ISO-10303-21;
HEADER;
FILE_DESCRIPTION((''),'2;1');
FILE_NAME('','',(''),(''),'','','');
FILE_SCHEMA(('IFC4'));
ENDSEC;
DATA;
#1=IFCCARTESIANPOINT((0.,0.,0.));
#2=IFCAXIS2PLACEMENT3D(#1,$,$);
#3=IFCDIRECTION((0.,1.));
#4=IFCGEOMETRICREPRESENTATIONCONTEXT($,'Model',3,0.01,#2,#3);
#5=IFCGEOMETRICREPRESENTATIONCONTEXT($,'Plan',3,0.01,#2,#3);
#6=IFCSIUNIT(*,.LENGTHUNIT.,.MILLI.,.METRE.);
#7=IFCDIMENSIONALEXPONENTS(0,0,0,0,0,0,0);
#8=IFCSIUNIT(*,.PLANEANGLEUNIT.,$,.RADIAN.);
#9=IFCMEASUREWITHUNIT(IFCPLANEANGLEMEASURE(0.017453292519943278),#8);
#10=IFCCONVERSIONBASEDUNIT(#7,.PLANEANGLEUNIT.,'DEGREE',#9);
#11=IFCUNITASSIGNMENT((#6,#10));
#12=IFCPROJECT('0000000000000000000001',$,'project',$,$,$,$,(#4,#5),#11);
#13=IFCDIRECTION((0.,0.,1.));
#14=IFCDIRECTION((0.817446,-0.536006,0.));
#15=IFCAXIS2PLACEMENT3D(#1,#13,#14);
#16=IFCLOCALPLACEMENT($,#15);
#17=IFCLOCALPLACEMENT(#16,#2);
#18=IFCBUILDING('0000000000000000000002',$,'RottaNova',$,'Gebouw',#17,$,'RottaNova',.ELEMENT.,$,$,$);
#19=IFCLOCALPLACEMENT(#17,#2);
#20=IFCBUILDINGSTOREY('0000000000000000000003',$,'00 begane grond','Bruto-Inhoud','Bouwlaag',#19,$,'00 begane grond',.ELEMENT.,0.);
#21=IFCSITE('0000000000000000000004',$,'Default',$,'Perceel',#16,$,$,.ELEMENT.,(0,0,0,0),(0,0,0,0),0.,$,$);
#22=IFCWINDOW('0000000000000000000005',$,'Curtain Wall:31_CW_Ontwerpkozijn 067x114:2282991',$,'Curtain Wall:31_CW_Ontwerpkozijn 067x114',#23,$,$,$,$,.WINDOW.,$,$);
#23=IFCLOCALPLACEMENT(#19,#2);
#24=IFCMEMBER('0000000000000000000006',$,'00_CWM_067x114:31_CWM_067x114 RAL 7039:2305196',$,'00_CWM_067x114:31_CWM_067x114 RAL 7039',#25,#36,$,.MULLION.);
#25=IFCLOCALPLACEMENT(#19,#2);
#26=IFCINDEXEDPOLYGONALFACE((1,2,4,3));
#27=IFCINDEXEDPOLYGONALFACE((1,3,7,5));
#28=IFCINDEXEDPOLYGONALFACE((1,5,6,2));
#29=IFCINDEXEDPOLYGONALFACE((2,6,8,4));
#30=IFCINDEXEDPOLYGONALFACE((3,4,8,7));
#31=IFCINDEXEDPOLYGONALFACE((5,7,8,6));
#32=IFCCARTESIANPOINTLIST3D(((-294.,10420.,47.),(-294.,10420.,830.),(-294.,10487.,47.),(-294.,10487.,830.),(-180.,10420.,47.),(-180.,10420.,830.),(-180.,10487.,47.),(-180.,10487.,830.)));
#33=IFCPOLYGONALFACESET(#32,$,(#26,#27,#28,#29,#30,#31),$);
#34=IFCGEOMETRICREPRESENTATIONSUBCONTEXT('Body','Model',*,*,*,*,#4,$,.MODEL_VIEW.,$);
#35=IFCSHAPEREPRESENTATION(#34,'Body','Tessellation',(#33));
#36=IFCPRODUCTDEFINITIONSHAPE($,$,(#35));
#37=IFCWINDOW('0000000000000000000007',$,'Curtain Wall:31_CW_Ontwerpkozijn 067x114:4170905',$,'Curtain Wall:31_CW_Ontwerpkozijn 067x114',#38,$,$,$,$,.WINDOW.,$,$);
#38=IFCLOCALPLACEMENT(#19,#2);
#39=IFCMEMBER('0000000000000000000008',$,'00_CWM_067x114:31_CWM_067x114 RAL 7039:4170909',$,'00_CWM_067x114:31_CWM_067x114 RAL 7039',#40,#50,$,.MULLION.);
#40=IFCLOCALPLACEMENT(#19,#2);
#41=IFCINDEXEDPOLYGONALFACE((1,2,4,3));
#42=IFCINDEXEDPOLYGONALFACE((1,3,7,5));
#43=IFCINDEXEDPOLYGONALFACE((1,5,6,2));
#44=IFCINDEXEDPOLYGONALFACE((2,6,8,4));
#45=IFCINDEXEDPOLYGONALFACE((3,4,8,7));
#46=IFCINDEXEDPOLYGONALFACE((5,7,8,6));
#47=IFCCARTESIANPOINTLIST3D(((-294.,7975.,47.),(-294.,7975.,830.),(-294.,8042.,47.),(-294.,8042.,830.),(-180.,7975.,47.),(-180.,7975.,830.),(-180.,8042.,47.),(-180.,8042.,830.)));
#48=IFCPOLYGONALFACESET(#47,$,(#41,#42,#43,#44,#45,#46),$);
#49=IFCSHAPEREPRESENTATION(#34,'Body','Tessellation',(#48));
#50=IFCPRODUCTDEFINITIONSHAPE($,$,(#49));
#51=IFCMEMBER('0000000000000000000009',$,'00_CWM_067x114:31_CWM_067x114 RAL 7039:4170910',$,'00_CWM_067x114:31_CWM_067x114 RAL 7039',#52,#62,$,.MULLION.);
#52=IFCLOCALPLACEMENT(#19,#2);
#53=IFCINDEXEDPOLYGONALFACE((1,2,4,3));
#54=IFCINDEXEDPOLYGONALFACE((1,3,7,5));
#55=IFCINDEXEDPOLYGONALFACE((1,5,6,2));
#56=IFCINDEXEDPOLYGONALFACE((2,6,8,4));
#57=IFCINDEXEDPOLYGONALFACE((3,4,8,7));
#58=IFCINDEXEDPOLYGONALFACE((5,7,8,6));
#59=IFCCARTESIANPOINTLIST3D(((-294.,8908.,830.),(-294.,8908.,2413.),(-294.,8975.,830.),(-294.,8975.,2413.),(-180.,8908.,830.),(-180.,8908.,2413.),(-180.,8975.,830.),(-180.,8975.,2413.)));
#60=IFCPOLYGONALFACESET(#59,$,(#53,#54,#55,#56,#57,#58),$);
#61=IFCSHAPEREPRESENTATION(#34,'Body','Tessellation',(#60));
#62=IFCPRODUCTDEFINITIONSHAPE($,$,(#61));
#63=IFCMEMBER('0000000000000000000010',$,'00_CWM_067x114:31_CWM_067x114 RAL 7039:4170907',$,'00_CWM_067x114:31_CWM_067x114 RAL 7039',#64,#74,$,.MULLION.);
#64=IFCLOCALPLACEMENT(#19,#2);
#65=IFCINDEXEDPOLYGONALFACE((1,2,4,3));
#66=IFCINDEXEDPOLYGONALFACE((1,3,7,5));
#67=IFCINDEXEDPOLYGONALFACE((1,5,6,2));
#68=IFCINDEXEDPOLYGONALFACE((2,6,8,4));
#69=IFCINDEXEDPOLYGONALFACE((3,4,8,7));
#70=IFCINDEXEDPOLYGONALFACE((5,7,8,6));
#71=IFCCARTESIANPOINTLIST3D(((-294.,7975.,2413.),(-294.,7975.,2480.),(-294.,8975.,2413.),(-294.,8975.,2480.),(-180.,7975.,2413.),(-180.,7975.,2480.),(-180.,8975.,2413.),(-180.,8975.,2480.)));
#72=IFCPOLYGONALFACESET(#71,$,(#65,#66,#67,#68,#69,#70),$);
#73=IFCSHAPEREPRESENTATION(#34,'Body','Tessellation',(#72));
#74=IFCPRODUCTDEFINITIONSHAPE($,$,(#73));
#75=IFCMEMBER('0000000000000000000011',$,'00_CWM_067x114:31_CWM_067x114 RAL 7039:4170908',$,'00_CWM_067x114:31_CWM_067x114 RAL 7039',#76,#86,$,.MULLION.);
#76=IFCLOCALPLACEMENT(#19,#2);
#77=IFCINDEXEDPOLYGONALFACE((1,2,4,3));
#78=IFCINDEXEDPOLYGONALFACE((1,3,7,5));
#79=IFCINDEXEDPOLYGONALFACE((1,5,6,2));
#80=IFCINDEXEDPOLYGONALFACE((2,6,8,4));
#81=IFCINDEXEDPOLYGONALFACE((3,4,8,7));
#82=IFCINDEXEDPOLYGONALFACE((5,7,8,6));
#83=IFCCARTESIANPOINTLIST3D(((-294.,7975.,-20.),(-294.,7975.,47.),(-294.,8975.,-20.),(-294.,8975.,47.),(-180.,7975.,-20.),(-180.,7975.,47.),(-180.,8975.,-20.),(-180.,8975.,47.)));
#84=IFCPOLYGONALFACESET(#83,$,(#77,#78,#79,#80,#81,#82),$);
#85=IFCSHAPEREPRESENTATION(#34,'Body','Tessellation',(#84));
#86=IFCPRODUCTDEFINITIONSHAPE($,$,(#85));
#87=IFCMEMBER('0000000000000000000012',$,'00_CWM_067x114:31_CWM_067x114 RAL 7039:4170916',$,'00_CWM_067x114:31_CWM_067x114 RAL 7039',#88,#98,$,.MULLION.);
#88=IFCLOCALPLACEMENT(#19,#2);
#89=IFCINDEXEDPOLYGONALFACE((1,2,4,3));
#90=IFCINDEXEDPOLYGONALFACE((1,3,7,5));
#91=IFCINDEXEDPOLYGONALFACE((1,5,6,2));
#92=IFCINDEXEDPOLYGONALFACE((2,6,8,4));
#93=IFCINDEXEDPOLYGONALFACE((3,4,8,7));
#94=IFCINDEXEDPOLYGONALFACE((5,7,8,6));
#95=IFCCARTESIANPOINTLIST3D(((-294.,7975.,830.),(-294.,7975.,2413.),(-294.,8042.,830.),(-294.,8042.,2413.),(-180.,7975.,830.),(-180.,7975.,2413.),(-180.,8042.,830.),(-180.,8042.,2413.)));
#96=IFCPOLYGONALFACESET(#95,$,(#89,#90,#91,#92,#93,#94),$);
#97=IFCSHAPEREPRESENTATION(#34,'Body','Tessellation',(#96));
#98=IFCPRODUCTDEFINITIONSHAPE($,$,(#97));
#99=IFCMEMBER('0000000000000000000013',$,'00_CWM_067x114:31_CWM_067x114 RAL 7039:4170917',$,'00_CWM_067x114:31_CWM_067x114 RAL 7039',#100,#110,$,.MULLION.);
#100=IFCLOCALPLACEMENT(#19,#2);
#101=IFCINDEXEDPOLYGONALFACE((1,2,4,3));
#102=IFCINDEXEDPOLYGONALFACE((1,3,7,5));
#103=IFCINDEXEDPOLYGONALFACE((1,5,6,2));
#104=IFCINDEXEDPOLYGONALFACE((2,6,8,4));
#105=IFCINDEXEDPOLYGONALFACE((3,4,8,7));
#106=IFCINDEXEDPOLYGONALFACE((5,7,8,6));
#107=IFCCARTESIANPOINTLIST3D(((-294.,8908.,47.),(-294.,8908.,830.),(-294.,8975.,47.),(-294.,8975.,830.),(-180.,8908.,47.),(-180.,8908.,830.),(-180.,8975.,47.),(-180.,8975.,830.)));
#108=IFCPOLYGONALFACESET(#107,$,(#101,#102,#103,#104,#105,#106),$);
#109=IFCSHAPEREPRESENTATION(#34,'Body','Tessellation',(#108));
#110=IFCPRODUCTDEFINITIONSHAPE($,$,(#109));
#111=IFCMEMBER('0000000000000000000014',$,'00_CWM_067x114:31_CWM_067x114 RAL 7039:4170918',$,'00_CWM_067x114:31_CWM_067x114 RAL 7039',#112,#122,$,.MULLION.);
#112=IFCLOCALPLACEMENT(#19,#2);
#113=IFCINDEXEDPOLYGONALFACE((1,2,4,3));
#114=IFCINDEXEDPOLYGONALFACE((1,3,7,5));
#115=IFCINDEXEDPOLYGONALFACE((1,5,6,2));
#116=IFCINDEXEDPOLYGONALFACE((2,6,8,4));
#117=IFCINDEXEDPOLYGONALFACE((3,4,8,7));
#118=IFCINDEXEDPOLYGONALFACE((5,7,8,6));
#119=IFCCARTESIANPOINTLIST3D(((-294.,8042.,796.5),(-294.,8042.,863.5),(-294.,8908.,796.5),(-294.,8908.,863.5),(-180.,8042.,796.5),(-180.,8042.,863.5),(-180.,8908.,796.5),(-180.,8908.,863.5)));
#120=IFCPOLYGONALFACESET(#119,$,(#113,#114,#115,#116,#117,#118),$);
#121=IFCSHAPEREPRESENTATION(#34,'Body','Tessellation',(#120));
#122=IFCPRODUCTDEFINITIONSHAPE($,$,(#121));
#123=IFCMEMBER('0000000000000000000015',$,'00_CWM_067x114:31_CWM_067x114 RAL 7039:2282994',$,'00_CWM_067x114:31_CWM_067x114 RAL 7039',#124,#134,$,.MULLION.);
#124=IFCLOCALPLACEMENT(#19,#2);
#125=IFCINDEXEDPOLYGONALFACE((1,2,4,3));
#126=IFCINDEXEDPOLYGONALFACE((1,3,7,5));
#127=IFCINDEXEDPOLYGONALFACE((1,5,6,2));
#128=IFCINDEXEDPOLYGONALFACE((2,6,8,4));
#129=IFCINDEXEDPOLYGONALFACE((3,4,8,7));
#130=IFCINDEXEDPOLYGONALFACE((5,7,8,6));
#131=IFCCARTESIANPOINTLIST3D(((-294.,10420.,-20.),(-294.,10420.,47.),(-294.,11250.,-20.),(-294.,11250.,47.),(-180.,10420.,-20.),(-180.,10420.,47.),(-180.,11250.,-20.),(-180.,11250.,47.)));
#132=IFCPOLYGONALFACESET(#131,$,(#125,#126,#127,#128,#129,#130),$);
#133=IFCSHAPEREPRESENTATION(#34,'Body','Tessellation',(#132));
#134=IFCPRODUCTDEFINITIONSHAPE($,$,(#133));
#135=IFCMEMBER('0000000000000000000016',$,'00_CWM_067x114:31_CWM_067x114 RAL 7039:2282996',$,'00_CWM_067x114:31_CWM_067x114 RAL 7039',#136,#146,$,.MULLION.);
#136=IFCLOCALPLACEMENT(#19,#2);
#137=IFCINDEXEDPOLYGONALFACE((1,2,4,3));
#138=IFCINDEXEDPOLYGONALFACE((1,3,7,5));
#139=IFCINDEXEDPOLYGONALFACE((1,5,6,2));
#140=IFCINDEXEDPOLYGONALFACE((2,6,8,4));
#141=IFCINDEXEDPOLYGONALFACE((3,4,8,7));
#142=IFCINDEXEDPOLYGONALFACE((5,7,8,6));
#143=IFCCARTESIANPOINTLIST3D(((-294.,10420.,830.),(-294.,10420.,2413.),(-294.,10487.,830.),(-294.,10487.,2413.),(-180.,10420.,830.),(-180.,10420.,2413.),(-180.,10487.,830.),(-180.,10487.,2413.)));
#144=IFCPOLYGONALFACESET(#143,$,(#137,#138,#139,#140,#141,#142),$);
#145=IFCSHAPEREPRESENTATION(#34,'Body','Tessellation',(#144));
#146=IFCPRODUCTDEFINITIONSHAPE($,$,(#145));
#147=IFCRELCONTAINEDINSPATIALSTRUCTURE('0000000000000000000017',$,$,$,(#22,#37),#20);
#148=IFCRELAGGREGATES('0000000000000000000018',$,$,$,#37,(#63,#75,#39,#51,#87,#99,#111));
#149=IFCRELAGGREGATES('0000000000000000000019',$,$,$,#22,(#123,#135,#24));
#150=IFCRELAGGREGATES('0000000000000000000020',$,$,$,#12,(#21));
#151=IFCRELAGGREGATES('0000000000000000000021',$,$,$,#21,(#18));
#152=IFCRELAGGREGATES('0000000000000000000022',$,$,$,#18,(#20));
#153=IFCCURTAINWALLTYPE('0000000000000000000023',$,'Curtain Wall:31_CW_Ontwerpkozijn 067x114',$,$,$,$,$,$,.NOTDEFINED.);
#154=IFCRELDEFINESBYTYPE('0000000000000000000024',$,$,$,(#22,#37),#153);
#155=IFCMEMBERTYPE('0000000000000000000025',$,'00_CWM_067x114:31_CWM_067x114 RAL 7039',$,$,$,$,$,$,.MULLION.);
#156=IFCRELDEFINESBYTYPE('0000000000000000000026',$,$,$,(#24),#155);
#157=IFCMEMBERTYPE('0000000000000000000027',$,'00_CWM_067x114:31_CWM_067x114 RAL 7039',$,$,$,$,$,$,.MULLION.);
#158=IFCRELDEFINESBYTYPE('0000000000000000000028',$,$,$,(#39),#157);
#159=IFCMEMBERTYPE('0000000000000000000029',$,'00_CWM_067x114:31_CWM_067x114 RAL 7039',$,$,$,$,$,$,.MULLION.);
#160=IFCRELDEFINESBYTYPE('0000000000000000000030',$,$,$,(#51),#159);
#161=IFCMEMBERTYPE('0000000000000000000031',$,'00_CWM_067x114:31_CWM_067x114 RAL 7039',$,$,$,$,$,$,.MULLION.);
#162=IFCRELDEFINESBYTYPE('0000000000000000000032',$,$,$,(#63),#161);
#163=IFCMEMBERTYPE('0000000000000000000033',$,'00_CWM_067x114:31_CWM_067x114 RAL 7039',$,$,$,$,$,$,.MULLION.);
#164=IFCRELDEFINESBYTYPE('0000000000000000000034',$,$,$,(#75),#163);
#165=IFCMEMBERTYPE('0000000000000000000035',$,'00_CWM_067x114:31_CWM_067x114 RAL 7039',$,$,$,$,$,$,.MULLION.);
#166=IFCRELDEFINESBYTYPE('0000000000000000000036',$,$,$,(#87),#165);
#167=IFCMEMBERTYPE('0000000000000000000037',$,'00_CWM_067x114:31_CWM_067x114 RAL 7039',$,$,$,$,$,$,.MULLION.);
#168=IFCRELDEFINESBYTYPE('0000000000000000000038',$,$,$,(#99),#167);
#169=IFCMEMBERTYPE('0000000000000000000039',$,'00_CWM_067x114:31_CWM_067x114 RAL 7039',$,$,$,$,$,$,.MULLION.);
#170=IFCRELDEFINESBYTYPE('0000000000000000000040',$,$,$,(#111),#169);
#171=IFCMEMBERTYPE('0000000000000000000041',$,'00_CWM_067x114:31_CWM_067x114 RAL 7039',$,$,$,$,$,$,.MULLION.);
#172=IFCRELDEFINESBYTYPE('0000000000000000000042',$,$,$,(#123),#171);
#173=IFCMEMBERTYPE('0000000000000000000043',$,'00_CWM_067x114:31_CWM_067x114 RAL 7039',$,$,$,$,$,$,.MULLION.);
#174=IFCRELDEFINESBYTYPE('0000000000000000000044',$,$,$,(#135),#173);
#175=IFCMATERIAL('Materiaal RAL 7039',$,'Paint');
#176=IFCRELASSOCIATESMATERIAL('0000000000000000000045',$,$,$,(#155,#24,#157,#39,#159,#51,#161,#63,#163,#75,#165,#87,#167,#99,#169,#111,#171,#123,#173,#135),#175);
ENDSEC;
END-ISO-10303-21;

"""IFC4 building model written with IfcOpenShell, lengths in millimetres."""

from ifc_helpers import new_model, entity, si_unit, converted_unit, direction, frame, origin, place, context, subcontext, project, spatial, indexed_curve, outline, extrude, source, transform, mapped, material, type_object, type_shapes, element, aggregate, save


model = new_model("IFC4")

# Units and contexts
model_context = context("Model", 3, precision=0.01, world=origin(), true_north=direction((0.0, 1.0)))
plan_context = context("Plan", 3, precision=0.01, world=origin(), true_north=direction((0.0, 1.0)))
body_context = subcontext(model_context, "Body", "Model", "MODEL_VIEW")
ifc_project = project(units=[si_unit("LENGTHUNIT", "METRE", prefix="MILLI"), converted_unit("PLANEANGLEUNIT", "DEGREE", entity("IfcPlaneAngleMeasure", 0.017453292519943278), si_unit("PLANEANGLEUNIT", "RADIAN"), dimensions=[0, 0, 0, 0, 0, 0, 0])], contexts=[model_context, plan_context])

# Site, building, storey
site_placement = place(None, frame((0.0, 0.0, 0.0), z_axis=(0.0, 0.0, 1.0), x_axis=(0.817446, -0.536006, 0.0)))
site = spatial("IfcSite", under=ifc_project, at=site_placement, Name="Default", ObjectType="Perceel", CompositionType="ELEMENT", RefLatitude=(0, 0, 0, 0), RefLongitude=(0, 0, 0, 0), RefElevation=0.0)
building_placement = place(site_placement, origin())
building = spatial("IfcBuilding", under=site, at=building_placement, Name="RottaNova", ObjectType="Gebouw", LongName="RottaNova", CompositionType="ELEMENT")
storey_placement = place(building_placement, origin())
storey = spatial("IfcBuildingStorey", under=building, at=storey_placement, Name="00 begane grond", Description="Bruto-Inhoud", ObjectType="Bouwlaag", LongName="00 begane grond", CompositionType="ELEMENT", Elevation=0.0)

# Window, member
curtain_wall_type = type_object("IfcCurtainWallType", Name="Curtain Wall:31_CW_Ontwerpkozijn 067x114", PredefinedType="NOTDEFINED")
window_1_placement = place(storey_placement, origin())
window_1 = element("IfcWindow", 1, at=window_1_placement, inside=storey, type_object=curtain_wall_type, Name="Curtain Wall:31_CW_Ontwerpkozijn 067x114:2282991", ObjectType="Curtain Wall:31_CW_Ontwerpkozijn 067x114", PredefinedType="WINDOW")
ifc_material_1 = material(Name="Materiaal RAL 7039", Category="Paint")
member_type_1 = type_object("IfcMemberType", Name="00_CWM_067x114:31_CWM_067x114 RAL 7039", PredefinedType="MULLION", material=ifc_material_1)
shared_shape_1 = source(origin(), body_context, "Body", "SweptSolid", [
    extrude(outline(indexed_curve([(-33.5, -57.0), (33.5, -57.0), (33.5, 57.0), (-33.5, 57.0), (-33.5, -57.0)], self_intersect=False)), frame((-33.5, -57.0, -783.0), z_axis=(0.0, 0.0, 1.0), x_axis=(-1.0, 0.0, 0.0)), (0.0, 0.0, 1.0), 783.0),
])
type_shapes(member_type_1, [shared_shape_1])
member_1_placement = place(window_1_placement, frame((-180.0, 10420.0, 830.0), z_axis=(0.0, 0.0, 1.0), x_axis=(0.0, -1.0, 0.0)))
member_1 = element("IfcMember", 2, at=member_1_placement, type_object=member_type_1, material=ifc_material_1, Name="00_CWM_067x114:31_CWM_067x114 RAL 7039:2305196", ObjectType="00_CWM_067x114:31_CWM_067x114 RAL 7039", PredefinedType="MULLION", context=body_context, shape_type="MappedRepresentation", body=[
    mapped(shared_shape_1, transform((0.0, 0.0, 0.0), scale=1.0)),
])

# Window, members
window_2_placement = place(storey_placement, origin())
window_2 = element("IfcWindow", 3, at=window_2_placement, inside=storey, type_object=curtain_wall_type, Name="Curtain Wall:31_CW_Ontwerpkozijn 067x114:4170905", ObjectType="Curtain Wall:31_CW_Ontwerpkozijn 067x114", PredefinedType="WINDOW")
member_type_2 = type_object("IfcMemberType", Name="00_CWM_067x114:31_CWM_067x114 RAL 7039", PredefinedType="MULLION", material=ifc_material_1)
shared_shape_2 = source(origin(), body_context, "Body", "SweptSolid", [
    extrude(outline(indexed_curve([(-33.5, -57.0), (33.5, -57.0), (33.5, 57.0), (-33.5, 57.0), (-33.5, -57.0)], self_intersect=False)), frame((-33.5, 57.0, -783.0), z_axis=(0.0, 0.0, 1.0), x_axis=(-1.0, 0.0, 0.0)), (0.0, 0.0, 1.0), 783.0),
])
type_shapes(member_type_2, [shared_shape_2])
member_2_placement = place(window_2_placement, frame((-180.0, 7975.0, 47.0), z_axis=(0.0, 0.0, -1.0), x_axis=(0.0, -1.0, 0.0)))
member_2 = element("IfcMember", 4, at=member_2_placement, type_object=member_type_2, material=ifc_material_1, Name="00_CWM_067x114:31_CWM_067x114 RAL 7039:4170909", ObjectType="00_CWM_067x114:31_CWM_067x114 RAL 7039", PredefinedType="MULLION", context=body_context, shape_type="MappedRepresentation", body=[
    mapped(shared_shape_2, transform((0.0, 0.0, 0.0), scale=1.0)),
])
member_type_3 = type_object("IfcMemberType", Name="00_CWM_067x114:31_CWM_067x114 RAL 7039", PredefinedType="MULLION", material=ifc_material_1)
shared_shape_3 = source(origin(), body_context, "Body", "SweptSolid", [
    extrude(outline(indexed_curve([(-33.5, -57.0), (33.5, -57.0), (33.5, 57.0), (-33.5, 57.0), (-33.5, -57.0)], self_intersect=False)), frame((-33.5, 57.0, -1583.0), z_axis=(0.0, 0.0, 1.0), x_axis=(-1.0, 0.0, 0.0)), (0.0, 0.0, 1.0), 1583.0),
])
type_shapes(member_type_3, [shared_shape_3])
member_3_placement = place(window_2_placement, frame((-180.0, 8975.0, 2413.0), z_axis=(0.0, 0.0, 1.0), x_axis=(0.0, 1.0, 0.0)))
member_3 = element("IfcMember", 5, at=member_3_placement, type_object=member_type_3, material=ifc_material_1, Name="00_CWM_067x114:31_CWM_067x114 RAL 7039:4170910", ObjectType="00_CWM_067x114:31_CWM_067x114 RAL 7039", PredefinedType="MULLION", context=body_context, shape_type="MappedRepresentation", body=[
    mapped(shared_shape_3, transform((0.0, 0.0, 0.0), scale=1.0)),
])
member_type_4 = type_object("IfcMemberType", Name="00_CWM_067x114:31_CWM_067x114 RAL 7039", PredefinedType="MULLION", material=ifc_material_1)
shared_shape_4 = source(origin(), body_context, "Body", "SweptSolid", [
    extrude(outline(indexed_curve([(-33.5, -57.0), (33.5, -57.0), (33.5, 57.0), (-33.5, 57.0), (-33.5, -57.0)], self_intersect=False)), frame((-33.5, 57.0, -1000.0), z_axis=(0.0, 0.0, 1.0), x_axis=(-1.0, 0.0, 0.0)), (0.0, 0.0, 1.0), 1000.0),
])
type_shapes(member_type_4, [shared_shape_4])
member_4_placement = place(window_2_placement, frame((-180.0, 7975.0, 2480.0), z_axis=(0.0, -1.0, 0.0), x_axis=(0.0, 0.0, 1.0)))
member_4 = element("IfcMember", 6, at=member_4_placement, type_object=member_type_4, material=ifc_material_1, Name="00_CWM_067x114:31_CWM_067x114 RAL 7039:4170907", ObjectType="00_CWM_067x114:31_CWM_067x114 RAL 7039", PredefinedType="MULLION", context=body_context, shape_type="MappedRepresentation", body=[
    mapped(shared_shape_4, transform((0.0, 0.0, 0.0), scale=1.0)),
])
member_type_5 = type_object("IfcMemberType", Name="00_CWM_067x114:31_CWM_067x114 RAL 7039", PredefinedType="MULLION", material=ifc_material_1)
shared_shape_5 = source(origin(), body_context, "Body", "SweptSolid", [
    extrude(outline(indexed_curve([(-33.5, -57.0), (33.5, -57.0), (33.5, 57.0), (-33.5, 57.0), (-33.5, -57.0)], self_intersect=False)), frame((-33.5, 57.0, -1000.0), z_axis=(0.0, 0.0, 1.0), x_axis=(-1.0, 0.0, 0.0)), (0.0, 0.0, 1.0), 1000.0),
])
type_shapes(member_type_5, [shared_shape_5])
member_5_placement = place(window_2_placement, frame((-180.0, 8975.0, -20.0), z_axis=(0.0, 1.0, 0.0), x_axis=(0.0, 0.0, -1.0)))
member_5 = element("IfcMember", 7, at=member_5_placement, type_object=member_type_5, material=ifc_material_1, Name="00_CWM_067x114:31_CWM_067x114 RAL 7039:4170908", ObjectType="00_CWM_067x114:31_CWM_067x114 RAL 7039", PredefinedType="MULLION", context=body_context, shape_type="MappedRepresentation", body=[
    mapped(shared_shape_5, transform((0.0, 0.0, 0.0), scale=1.0)),
])
member_type_6 = type_object("IfcMemberType", Name="00_CWM_067x114:31_CWM_067x114 RAL 7039", PredefinedType="MULLION", material=ifc_material_1)
shared_shape_6 = source(origin(), body_context, "Body", "SweptSolid", [
    extrude(outline(indexed_curve([(-33.5, -57.0), (33.5, -57.0), (33.5, 57.0), (-33.5, 57.0), (-33.5, -57.0)], self_intersect=False)), frame((-33.5, 57.0, -1583.0), z_axis=(0.0, 0.0, 1.0), x_axis=(-1.0, 0.0, 0.0)), (0.0, 0.0, 1.0), 1583.0),
])
type_shapes(member_type_6, [shared_shape_6])
member_6_placement = place(window_2_placement, frame((-180.0, 7975.0, 830.0), z_axis=(0.0, 0.0, -1.0), x_axis=(0.0, -1.0, 0.0)))
member_6 = element("IfcMember", 8, at=member_6_placement, type_object=member_type_6, material=ifc_material_1, Name="00_CWM_067x114:31_CWM_067x114 RAL 7039:4170916", ObjectType="00_CWM_067x114:31_CWM_067x114 RAL 7039", PredefinedType="MULLION", context=body_context, shape_type="MappedRepresentation", body=[
    mapped(shared_shape_6, transform((0.0, 0.0, 0.0), scale=1.0)),
])
member_type_7 = type_object("IfcMemberType", Name="00_CWM_067x114:31_CWM_067x114 RAL 7039", PredefinedType="MULLION", material=ifc_material_1)
shared_shape_7 = source(origin(), body_context, "Body", "SweptSolid", [
    extrude(outline(indexed_curve([(-33.5, -57.0), (33.5, -57.0), (33.5, 57.0), (-33.5, 57.0), (-33.5, -57.0)], self_intersect=False)), frame((-33.5, 57.0, -783.0), z_axis=(0.0, 0.0, 1.0), x_axis=(-1.0, 0.0, 0.0)), (0.0, 0.0, 1.0), 783.0),
])
type_shapes(member_type_7, [shared_shape_7])
member_7_placement = place(window_2_placement, frame((-180.0, 8975.0, 830.0), z_axis=(0.0, 0.0, 1.0), x_axis=(0.0, 1.0, 0.0)))
member_7 = element("IfcMember", 9, at=member_7_placement, type_object=member_type_7, material=ifc_material_1, Name="00_CWM_067x114:31_CWM_067x114 RAL 7039:4170917", ObjectType="00_CWM_067x114:31_CWM_067x114 RAL 7039", PredefinedType="MULLION", context=body_context, shape_type="MappedRepresentation", body=[
    mapped(shared_shape_7, transform((0.0, 0.0, 0.0), scale=1.0)),
])
member_type_8 = type_object("IfcMemberType", Name="00_CWM_067x114:31_CWM_067x114 RAL 7039", PredefinedType="MULLION", material=ifc_material_1)
shared_shape_8 = source(origin(), body_context, "Body", "SweptSolid", [
    extrude(outline(indexed_curve([(-33.5, -57.0), (33.5, -57.0), (33.5, 57.0), (-33.5, 57.0), (-33.5, -57.0)], self_intersect=False)), frame((0.0, 57.0, -866.0), z_axis=(0.0, 0.0, 1.0), x_axis=(-1.0, 0.0, 0.0)), (0.0, 0.0, 1.0), 866.0),
])
type_shapes(member_type_8, [shared_shape_8])
member_8_placement = place(window_2_placement, frame((-180.0, 8042.0, 830.0), z_axis=(0.0, -1.0, 0.0), x_axis=(0.0, 0.0, 1.0)))
member_8 = element("IfcMember", 10, at=member_8_placement, type_object=member_type_8, material=ifc_material_1, Name="00_CWM_067x114:31_CWM_067x114 RAL 7039:4170918", ObjectType="00_CWM_067x114:31_CWM_067x114 RAL 7039", PredefinedType="MULLION", context=body_context, shape_type="MappedRepresentation", body=[
    mapped(shared_shape_8, transform((0.0, 0.0, 0.0), scale=1.0)),
])

# Members
member_type_9 = type_object("IfcMemberType", Name="00_CWM_067x114:31_CWM_067x114 RAL 7039", PredefinedType="MULLION", material=ifc_material_1)
shared_shape_9 = source(origin(), body_context, "Body", "SweptSolid", [
    extrude(outline(indexed_curve([(-33.5, -57.0), (33.5, -57.0), (33.5, 57.0), (-33.5, 57.0), (-33.5, -57.0)], self_intersect=False)), frame((-33.5, -57.0, -830.0), z_axis=(0.0, 0.0, 1.0), x_axis=(-1.0, 0.0, 0.0)), (0.0, 0.0, 1.0), 830.0),
])
type_shapes(member_type_9, [shared_shape_9])
member_9_placement = place(window_1_placement, frame((-180.0, 10420.0, -20.0), z_axis=(0.0, -1.0, 0.0), x_axis=(0.0, 0.0, -1.0)))
member_9 = element("IfcMember", 11, at=member_9_placement, type_object=member_type_9, material=ifc_material_1, Name="00_CWM_067x114:31_CWM_067x114 RAL 7039:2282994", ObjectType="00_CWM_067x114:31_CWM_067x114 RAL 7039", PredefinedType="MULLION", context=body_context, shape_type="MappedRepresentation", body=[
    mapped(shared_shape_9, transform((0.0, 0.0, 0.0), scale=1.0)),
])
member_type_10 = type_object("IfcMemberType", Name="00_CWM_067x114:31_CWM_067x114 RAL 7039", PredefinedType="MULLION", material=ifc_material_1)
shared_shape_10 = source(origin(), body_context, "Body", "SweptSolid", [
    extrude(outline(indexed_curve([(-33.5, -57.0), (33.5, -57.0), (33.5, 57.0), (-33.5, 57.0), (-33.5, -57.0)], self_intersect=False)), frame((-33.5, -57.0, -1583.0), z_axis=(0.0, 0.0, 1.0), x_axis=(-1.0, 0.0, 0.0)), (0.0, 0.0, 1.0), 1583.0),
])
type_shapes(member_type_10, [shared_shape_10])
member_10_placement = place(window_1_placement, frame((-180.0, 10420.0, 2413.0), z_axis=(0.0, 0.0, 1.0), x_axis=(0.0, -1.0, 0.0)))
member_10 = element("IfcMember", 12, at=member_10_placement, type_object=member_type_10, material=ifc_material_1, Name="00_CWM_067x114:31_CWM_067x114 RAL 7039:2282996", ObjectType="00_CWM_067x114:31_CWM_067x114 RAL 7039", PredefinedType="MULLION", context=body_context, shape_type="MappedRepresentation", body=[
    mapped(shared_shape_10, transform((0.0, 0.0, 0.0), scale=1.0)),
])

aggregate(window_2, [member_4, member_5, member_2, member_3, member_6, member_7, member_8])
aggregate(window_1, [member_9, member_10, member_1])

save(model, "model.ifc")
